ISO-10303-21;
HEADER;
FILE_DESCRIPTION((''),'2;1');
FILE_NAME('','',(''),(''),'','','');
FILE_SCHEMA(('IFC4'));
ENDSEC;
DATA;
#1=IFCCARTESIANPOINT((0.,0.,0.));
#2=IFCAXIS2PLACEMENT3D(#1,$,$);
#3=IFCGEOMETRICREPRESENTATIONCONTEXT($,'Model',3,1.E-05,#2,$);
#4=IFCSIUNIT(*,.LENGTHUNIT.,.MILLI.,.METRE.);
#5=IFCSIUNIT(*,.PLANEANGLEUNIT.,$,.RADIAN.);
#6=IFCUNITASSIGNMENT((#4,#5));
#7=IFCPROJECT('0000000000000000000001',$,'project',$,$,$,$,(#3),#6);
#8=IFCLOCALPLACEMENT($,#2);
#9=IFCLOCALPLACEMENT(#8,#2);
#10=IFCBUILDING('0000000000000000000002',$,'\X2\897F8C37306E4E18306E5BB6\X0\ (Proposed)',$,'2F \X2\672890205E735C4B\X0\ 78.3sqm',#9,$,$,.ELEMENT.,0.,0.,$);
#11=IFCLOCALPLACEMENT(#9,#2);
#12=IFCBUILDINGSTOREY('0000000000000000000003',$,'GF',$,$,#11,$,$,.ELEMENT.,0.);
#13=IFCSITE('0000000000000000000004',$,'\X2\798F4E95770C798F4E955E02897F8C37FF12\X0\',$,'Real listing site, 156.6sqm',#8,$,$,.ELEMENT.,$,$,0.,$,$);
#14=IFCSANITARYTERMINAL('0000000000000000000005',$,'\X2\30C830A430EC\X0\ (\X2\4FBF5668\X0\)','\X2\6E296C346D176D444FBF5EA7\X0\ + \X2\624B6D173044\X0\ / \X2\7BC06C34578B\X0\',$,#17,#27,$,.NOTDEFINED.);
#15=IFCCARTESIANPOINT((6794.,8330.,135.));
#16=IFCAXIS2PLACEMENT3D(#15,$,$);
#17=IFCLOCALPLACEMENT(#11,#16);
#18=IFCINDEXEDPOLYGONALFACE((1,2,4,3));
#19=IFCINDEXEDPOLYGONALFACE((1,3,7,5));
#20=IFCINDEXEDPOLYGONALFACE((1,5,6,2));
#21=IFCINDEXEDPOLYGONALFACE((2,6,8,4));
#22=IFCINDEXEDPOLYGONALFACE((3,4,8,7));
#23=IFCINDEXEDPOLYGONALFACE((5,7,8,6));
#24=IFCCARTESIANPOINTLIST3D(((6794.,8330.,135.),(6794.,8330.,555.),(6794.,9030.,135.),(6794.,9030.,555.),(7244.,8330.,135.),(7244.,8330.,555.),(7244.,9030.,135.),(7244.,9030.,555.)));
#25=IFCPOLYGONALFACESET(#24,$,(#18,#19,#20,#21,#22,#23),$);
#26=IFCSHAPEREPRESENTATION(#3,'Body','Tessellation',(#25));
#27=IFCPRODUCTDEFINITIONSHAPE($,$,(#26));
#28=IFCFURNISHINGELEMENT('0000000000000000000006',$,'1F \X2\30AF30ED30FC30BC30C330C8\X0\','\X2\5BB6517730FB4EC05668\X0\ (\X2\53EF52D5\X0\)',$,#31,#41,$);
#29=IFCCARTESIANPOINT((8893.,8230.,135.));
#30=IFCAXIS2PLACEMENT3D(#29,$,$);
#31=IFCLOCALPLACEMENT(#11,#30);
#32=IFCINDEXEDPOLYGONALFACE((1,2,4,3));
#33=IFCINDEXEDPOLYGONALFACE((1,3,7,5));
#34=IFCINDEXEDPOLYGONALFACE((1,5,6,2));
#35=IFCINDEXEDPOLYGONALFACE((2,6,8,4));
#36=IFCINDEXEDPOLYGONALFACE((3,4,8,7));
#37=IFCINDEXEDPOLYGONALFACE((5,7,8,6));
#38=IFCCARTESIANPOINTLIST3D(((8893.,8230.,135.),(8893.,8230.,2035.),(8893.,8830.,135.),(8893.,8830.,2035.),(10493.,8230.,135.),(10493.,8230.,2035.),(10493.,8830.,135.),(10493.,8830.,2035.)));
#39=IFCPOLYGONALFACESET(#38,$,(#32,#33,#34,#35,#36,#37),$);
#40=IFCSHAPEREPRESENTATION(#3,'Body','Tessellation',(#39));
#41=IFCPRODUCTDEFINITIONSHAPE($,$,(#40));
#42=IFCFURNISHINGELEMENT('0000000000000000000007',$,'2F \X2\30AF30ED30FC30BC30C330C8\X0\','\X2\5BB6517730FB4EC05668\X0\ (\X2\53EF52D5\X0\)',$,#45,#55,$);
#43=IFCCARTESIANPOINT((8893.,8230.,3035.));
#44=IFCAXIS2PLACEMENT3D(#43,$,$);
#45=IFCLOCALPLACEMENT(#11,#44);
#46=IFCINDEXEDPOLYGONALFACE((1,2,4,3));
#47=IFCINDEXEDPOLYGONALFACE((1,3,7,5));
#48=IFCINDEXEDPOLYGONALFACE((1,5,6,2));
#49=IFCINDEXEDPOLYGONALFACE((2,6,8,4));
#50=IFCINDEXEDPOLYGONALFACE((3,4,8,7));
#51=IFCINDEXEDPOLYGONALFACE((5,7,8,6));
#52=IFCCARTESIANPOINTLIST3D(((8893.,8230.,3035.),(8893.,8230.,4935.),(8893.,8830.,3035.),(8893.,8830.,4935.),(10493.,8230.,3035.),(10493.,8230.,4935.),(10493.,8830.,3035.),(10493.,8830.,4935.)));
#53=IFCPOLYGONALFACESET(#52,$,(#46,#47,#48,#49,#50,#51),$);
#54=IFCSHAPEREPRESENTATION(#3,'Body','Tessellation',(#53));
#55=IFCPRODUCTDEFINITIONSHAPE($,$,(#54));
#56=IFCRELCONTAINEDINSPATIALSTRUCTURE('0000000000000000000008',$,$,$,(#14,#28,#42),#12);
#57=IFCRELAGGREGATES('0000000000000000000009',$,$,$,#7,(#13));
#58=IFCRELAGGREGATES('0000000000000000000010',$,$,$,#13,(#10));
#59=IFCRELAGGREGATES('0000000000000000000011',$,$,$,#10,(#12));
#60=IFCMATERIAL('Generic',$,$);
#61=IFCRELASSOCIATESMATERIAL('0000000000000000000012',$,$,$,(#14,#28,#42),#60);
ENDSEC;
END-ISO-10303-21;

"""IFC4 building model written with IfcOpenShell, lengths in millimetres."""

from ifc_helpers import new_model, si_unit, frame, frame_2d, origin, place, context, project, spatial, rectangle, extrude, material, element, save


model = new_model("IFC4")

# Units and contexts
model_context = context("Model", 3, precision=1e-05, world=origin())
ifc_project = project(units=[si_unit("LENGTHUNIT", "METRE", prefix="MILLI"), si_unit("PLANEANGLEUNIT", "RADIAN")], contexts=[model_context])

# Site, building, storey
site_placement = place(None, origin())
site = spatial("IfcSite", under=ifc_project, at=site_placement, Name="福井県福井市西谷２", ObjectType="Real listing site, 156.6sqm", CompositionType="ELEMENT", RefElevation=0.0)
building_placement = place(site_placement, origin())
building = spatial("IfcBuilding", under=site, at=building_placement, Name="西谷の丘の家 (Proposed)", ObjectType="2F 木造平屋 78.3sqm", CompositionType="ELEMENT", ElevationOfRefHeight=0.0, ElevationOfTerrain=0.0)
storey_placement = place(building_placement, origin())
storey = spatial("IfcBuildingStorey", under=building, at=storey_placement, Name="GF", CompositionType="ELEMENT", Elevation=0.0)

# Shared definitions
ifc_material_1 = material(Name="Generic")

# Sanitary terminal
sanitary_terminal_1_placement = place(storey_placement, frame((6794.0, 8330.0, 135.0)))
element("IfcSanitaryTerminal", 1, at=sanitary_terminal_1_placement, inside=storey, material=ifc_material_1, Name="トイレ (便器)", Description="温水洗浄便座 + 手洗い / 節水型", PredefinedType="NOTDEFINED", context=model_context, shape_type="SweptSolid", body=[
    extrude(rectangle(XDim=450.0, YDim=700.0, at=frame_2d((225.0, 350.0))), frame((6794.0, 8330.0, 135.0)), (0.0, 0.0, 1.0), 420.0),
])

# Furnishing elements
furnishing_1_placement = place(storey_placement, frame((8893.0, 8230.0, 135.0)))
element("IfcFurnishingElement", 2, at=furnishing_1_placement, inside=storey, material=ifc_material_1, Name="1F クローゼット", Description="家具・什器 (可動)", context=model_context, shape_type="SweptSolid", body=[
    extrude(rectangle(XDim=1600.0, YDim=600.0, at=frame_2d((800.0, 300.0))), frame((8893.0, 8230.0, 135.0)), (0.0, 0.0, 1.0), 1900.0),
])
furnishing_2_placement = place(storey_placement, frame((8893.0, 8230.0, 3035.0)))
element("IfcFurnishingElement", 3, at=furnishing_2_placement, inside=storey, material=ifc_material_1, Name="2F クローゼット", Description="家具・什器 (可動)", context=model_context, shape_type="SweptSolid", body=[
    extrude(rectangle(XDim=1600.0, YDim=600.0, at=frame_2d((800.0, 300.0))), frame((8893.0, 8230.0, 3035.0)), (0.0, 0.0, 1.0), 1900.0),
])

save(model, "model.ifc")
